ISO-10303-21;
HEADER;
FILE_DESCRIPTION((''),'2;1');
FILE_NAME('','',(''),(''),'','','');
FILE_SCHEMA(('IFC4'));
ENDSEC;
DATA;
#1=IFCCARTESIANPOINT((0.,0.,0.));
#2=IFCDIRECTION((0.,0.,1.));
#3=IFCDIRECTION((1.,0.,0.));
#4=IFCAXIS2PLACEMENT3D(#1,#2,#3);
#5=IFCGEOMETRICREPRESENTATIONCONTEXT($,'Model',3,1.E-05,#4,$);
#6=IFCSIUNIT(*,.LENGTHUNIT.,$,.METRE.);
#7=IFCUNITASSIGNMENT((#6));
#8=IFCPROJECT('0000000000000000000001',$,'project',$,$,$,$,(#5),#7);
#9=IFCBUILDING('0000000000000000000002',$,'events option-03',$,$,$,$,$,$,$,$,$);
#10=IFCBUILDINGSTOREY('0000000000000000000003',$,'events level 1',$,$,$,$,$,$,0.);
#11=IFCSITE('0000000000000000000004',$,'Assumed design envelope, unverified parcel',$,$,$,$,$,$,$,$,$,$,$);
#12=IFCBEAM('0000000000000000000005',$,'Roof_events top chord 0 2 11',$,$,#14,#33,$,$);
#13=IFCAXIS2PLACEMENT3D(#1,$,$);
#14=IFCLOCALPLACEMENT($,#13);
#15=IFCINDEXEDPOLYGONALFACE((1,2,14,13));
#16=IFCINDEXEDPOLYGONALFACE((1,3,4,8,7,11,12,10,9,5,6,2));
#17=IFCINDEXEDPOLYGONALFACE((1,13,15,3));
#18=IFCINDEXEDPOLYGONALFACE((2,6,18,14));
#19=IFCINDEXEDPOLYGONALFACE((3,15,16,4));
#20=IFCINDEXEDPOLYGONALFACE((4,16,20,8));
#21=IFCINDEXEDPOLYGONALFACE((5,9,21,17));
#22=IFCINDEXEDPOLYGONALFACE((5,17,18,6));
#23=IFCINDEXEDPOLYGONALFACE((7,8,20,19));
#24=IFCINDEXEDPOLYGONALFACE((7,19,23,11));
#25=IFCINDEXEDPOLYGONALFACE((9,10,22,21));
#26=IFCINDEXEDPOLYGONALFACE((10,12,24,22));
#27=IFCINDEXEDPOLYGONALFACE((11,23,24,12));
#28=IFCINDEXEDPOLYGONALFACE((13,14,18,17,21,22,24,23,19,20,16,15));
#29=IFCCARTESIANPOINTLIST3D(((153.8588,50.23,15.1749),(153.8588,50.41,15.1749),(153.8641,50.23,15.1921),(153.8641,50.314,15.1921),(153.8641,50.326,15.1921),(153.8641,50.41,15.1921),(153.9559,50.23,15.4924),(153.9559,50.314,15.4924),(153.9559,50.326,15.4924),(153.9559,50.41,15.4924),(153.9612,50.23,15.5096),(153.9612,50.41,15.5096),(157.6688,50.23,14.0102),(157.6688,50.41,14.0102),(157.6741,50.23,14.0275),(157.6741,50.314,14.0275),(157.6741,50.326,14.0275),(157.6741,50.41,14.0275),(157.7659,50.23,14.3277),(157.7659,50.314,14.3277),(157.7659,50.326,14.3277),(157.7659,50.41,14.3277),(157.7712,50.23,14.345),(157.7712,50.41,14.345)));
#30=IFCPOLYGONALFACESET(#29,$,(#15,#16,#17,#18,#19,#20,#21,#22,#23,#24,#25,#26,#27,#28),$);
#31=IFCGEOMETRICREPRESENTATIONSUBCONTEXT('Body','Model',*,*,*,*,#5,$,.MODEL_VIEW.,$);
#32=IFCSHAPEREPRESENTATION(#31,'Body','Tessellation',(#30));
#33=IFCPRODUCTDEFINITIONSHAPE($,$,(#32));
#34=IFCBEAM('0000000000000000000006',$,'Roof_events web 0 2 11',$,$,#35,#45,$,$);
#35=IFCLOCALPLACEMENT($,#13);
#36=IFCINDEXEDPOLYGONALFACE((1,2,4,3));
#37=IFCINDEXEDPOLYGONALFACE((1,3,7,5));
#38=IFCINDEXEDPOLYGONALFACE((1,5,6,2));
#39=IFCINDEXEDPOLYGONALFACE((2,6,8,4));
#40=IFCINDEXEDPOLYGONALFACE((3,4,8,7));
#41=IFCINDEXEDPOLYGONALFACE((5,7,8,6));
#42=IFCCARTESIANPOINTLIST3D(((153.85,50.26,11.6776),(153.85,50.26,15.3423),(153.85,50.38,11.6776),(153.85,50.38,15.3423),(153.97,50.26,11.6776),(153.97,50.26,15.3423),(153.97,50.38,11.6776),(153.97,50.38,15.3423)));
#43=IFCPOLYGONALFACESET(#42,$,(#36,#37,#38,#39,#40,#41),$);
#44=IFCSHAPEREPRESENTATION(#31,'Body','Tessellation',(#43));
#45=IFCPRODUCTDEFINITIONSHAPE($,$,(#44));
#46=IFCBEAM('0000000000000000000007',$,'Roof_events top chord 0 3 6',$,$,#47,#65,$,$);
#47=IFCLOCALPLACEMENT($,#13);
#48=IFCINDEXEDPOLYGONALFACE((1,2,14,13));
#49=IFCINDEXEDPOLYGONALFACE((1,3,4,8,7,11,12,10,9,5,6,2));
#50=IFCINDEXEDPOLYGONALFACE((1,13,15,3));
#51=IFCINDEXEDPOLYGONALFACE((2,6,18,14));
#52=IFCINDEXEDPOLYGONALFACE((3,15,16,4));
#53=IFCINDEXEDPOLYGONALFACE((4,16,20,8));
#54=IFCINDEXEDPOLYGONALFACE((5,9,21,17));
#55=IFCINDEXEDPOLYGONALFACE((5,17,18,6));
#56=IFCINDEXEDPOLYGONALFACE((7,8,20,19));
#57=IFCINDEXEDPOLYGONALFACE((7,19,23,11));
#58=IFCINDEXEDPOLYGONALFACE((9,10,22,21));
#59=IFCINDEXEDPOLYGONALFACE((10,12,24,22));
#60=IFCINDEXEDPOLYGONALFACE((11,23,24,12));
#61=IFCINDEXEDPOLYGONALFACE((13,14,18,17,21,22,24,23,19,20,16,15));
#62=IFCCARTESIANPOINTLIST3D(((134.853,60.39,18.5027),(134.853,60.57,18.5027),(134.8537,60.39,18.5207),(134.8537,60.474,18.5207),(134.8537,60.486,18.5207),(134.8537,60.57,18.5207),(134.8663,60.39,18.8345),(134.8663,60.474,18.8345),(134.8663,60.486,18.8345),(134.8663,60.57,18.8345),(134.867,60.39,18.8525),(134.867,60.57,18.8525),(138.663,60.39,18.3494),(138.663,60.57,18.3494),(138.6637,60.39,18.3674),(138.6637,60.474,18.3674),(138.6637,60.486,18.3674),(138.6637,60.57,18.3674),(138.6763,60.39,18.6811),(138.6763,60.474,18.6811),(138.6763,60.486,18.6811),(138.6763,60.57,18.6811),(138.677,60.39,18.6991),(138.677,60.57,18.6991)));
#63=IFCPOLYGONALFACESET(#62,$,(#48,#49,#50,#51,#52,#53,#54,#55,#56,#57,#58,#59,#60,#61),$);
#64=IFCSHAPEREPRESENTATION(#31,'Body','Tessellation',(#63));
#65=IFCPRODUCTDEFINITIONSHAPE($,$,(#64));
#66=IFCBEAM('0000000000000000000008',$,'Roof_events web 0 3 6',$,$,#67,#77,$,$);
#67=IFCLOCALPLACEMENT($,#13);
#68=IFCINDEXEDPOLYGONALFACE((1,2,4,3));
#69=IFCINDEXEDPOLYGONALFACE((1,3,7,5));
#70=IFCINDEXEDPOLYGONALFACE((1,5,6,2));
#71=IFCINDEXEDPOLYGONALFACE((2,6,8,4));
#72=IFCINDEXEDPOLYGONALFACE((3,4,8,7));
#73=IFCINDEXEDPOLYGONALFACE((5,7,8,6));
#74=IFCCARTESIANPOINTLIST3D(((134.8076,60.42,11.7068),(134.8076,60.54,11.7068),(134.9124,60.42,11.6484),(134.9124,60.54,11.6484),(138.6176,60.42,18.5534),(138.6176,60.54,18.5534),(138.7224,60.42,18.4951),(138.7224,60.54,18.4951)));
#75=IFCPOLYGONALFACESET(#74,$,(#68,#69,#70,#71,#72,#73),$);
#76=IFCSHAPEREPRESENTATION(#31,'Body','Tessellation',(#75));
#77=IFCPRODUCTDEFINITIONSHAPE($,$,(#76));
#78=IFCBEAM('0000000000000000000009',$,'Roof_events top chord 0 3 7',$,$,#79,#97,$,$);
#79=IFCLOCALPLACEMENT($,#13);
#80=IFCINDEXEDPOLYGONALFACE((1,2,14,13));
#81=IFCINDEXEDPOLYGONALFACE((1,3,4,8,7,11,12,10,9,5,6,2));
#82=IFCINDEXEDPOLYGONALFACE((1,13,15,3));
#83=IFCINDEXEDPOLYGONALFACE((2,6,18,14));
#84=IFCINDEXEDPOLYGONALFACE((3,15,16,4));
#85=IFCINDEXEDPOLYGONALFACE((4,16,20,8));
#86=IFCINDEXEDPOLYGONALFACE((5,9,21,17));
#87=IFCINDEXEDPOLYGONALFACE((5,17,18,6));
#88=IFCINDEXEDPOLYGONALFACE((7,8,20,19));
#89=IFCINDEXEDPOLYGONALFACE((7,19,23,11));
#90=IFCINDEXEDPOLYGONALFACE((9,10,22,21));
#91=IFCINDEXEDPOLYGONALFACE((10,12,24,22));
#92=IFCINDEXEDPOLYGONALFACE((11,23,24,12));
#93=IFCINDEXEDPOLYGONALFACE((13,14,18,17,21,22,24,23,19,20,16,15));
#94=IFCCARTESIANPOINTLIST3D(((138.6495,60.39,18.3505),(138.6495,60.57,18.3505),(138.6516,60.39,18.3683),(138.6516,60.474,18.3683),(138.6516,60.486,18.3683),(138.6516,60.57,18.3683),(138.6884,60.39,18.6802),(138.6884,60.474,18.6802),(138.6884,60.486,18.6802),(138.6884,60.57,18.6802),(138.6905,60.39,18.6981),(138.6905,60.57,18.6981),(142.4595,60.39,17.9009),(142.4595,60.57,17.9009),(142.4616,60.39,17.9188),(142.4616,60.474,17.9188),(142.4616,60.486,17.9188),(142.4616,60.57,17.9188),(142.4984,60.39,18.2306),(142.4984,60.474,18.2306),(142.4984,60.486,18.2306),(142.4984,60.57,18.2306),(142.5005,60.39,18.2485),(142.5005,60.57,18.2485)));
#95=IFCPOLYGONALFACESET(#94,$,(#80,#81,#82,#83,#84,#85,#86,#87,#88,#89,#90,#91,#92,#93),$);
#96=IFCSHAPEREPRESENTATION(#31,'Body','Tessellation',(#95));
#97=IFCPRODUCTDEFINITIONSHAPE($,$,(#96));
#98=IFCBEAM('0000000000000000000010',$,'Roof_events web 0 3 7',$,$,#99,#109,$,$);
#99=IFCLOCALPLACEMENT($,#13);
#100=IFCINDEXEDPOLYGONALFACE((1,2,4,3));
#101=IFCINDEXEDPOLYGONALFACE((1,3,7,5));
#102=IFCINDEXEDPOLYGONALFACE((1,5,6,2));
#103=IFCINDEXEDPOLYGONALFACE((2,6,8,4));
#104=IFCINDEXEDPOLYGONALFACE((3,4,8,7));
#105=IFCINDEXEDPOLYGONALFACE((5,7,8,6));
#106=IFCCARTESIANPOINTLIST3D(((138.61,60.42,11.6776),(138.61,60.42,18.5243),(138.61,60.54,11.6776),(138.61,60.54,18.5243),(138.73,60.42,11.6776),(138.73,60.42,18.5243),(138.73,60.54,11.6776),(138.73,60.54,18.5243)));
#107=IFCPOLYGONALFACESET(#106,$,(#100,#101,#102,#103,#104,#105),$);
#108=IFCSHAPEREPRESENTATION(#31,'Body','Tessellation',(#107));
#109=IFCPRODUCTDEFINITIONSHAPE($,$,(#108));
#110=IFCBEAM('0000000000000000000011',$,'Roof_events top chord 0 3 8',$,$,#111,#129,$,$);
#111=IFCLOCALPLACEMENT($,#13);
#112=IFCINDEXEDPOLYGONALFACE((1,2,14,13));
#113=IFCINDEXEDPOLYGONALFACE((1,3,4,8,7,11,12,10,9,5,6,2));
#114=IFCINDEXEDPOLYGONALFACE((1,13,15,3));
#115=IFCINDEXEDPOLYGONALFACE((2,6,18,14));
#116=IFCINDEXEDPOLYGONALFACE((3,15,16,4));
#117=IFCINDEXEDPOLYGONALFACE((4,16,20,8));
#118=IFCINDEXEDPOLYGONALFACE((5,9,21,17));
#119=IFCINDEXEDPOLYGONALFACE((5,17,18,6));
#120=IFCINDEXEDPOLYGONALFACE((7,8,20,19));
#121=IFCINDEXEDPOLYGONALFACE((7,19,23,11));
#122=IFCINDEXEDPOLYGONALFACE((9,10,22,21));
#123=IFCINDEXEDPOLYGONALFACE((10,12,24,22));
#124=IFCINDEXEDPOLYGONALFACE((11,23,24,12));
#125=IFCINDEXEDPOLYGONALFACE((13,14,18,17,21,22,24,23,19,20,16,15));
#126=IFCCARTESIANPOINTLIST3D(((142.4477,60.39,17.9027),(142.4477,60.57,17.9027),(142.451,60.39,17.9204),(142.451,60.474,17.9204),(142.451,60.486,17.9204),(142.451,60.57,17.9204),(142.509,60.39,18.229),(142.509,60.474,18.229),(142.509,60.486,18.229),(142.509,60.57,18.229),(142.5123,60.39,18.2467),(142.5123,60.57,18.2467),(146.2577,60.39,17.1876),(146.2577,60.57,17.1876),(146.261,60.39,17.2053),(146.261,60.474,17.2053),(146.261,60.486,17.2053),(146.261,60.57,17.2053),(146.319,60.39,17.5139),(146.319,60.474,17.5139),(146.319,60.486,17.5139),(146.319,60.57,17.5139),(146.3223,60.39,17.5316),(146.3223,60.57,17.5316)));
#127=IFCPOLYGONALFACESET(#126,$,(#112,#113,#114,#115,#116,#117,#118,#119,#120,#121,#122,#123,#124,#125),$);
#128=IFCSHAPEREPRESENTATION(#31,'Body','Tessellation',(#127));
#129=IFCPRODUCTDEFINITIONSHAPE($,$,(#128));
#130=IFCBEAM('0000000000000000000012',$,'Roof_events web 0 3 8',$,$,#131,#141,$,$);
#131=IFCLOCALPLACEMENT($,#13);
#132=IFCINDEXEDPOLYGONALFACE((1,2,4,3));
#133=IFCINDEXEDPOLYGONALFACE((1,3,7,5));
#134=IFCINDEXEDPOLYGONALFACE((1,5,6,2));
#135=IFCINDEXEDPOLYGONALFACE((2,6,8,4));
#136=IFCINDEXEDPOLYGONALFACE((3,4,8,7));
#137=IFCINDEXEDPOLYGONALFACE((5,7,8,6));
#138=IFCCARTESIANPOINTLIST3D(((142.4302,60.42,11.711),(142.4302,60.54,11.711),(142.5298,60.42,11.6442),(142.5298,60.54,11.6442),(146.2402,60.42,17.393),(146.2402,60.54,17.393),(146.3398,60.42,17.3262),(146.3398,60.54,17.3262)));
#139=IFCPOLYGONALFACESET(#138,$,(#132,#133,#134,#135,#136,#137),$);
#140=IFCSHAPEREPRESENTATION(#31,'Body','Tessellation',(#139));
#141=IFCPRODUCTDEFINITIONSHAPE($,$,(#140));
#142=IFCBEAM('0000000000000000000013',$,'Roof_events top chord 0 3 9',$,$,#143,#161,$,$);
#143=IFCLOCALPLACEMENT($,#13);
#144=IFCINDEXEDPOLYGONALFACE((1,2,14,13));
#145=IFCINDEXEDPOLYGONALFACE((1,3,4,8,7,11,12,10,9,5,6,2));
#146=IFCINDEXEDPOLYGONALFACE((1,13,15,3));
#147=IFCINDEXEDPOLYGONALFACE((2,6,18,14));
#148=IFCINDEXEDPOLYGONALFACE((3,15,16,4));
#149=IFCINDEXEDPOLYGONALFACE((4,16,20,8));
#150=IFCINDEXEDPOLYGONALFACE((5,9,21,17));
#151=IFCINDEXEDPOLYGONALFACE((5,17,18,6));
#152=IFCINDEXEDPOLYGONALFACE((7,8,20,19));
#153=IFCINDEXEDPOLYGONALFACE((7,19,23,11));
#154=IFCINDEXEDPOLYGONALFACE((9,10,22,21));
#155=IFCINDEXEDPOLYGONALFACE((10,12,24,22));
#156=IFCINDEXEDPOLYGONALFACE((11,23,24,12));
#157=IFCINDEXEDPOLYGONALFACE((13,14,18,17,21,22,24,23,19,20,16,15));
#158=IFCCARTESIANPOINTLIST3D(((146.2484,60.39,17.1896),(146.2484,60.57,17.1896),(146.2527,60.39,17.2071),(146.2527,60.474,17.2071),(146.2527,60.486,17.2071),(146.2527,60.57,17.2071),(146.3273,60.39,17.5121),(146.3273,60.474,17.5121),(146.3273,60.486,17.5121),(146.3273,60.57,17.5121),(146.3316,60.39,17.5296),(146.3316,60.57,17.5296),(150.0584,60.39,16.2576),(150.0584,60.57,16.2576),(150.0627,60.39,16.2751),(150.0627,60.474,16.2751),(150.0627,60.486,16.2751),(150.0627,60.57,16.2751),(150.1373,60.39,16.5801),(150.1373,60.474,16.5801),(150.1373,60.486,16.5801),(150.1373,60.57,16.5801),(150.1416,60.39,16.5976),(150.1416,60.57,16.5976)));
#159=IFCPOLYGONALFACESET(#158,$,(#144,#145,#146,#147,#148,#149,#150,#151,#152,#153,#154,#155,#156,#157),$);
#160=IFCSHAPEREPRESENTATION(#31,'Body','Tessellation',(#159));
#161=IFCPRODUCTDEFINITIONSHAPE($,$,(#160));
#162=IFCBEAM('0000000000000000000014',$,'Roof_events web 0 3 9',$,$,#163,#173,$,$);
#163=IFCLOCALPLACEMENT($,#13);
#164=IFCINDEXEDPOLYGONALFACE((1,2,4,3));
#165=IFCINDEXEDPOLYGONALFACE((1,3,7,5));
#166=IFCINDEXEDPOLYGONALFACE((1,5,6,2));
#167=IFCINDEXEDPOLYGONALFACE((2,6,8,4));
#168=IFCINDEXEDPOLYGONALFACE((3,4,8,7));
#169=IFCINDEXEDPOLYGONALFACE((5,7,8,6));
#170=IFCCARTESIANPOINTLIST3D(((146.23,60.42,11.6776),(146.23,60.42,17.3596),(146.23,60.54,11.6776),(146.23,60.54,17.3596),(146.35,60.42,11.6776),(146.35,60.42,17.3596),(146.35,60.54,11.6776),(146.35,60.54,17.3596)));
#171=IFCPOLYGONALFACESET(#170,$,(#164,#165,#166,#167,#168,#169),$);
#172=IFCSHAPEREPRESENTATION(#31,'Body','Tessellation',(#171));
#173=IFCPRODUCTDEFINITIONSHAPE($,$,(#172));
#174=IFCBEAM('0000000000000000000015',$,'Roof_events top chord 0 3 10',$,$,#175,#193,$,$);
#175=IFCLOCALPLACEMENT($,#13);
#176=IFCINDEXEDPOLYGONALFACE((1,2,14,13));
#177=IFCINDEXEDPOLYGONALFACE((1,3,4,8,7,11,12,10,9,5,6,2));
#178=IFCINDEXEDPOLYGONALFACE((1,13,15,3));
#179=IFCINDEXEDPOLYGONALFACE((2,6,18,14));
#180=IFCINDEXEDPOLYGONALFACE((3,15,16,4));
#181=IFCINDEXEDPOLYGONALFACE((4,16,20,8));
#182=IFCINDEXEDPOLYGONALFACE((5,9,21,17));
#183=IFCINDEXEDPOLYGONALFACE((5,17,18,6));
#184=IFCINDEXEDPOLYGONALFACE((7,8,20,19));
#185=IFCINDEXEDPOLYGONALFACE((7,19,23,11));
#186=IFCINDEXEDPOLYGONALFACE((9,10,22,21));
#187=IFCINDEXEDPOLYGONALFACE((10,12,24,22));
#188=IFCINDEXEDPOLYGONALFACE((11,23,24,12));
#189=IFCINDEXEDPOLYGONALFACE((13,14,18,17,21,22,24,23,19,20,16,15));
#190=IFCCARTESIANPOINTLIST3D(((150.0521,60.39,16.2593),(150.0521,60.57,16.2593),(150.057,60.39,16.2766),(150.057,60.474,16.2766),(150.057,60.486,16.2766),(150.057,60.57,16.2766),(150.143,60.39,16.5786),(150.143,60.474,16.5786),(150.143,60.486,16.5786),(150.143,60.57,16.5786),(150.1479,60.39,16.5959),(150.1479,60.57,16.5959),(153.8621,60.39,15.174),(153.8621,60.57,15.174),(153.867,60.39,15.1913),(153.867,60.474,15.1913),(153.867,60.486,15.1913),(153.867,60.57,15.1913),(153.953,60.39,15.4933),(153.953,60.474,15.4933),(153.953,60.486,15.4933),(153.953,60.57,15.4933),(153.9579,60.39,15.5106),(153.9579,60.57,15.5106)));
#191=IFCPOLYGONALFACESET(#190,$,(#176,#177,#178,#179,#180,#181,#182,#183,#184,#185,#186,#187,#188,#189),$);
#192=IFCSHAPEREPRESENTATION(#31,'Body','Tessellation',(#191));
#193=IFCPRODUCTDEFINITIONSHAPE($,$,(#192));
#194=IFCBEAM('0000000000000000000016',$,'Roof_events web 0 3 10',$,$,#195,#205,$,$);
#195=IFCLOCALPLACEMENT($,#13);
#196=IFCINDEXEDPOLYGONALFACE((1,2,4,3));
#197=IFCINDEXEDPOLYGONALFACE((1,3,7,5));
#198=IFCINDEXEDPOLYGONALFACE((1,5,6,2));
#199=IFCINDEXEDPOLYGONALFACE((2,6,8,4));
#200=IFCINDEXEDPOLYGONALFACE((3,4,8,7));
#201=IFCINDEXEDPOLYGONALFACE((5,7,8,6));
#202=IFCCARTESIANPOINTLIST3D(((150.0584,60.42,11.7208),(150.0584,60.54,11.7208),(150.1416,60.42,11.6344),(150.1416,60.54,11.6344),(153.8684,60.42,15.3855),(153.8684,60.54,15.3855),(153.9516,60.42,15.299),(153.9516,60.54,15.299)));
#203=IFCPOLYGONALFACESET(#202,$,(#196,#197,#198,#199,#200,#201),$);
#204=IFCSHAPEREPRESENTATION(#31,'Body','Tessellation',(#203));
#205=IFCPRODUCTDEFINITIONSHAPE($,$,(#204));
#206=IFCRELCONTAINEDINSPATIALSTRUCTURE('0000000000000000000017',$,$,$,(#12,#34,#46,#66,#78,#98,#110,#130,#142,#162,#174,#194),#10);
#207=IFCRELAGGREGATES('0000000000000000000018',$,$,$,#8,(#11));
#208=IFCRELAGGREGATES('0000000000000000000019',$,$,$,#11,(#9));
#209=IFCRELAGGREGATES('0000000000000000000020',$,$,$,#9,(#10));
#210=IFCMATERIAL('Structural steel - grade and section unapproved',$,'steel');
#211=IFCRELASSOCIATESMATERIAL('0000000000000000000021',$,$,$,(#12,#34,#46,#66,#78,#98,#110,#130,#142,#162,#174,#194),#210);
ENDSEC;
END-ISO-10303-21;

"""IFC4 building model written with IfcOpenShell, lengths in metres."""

from ifc_helpers import new_model, si_unit, frame, origin_with_axes, place, context, subcontext, project, spatial, rectangle, i_section, extrude, material, element, save


model = new_model("IFC4")

# Units and contexts
model_context = context("Model", 3, precision=1e-05, world=origin_with_axes())
body_context = subcontext(model_context, "Body", "Model", "MODEL_VIEW")
ifc_project = project(units=[si_unit("LENGTHUNIT", "METRE")], contexts=[model_context])

# Site, building, storey
site = spatial("IfcSite", under=ifc_project, Name="Assumed design envelope, unverified parcel")
building = spatial("IfcBuilding", under=site, Name="events option-03")
storey = spatial("IfcBuildingStorey", under=building, Name="events level 1", Elevation=0.0)

# Beams
ifc_material = material(Name="Structural steel - grade and section unapproved", Category="steel")
beam_1_placement = place(None, frame((153.91, 50.32, 15.3423), z_axis=(0.956315, 0.0, -0.292338), x_axis=(0.0, 1.0, 0.0)))
element("IfcBeam", 1, at=beam_1_placement, inside=storey, material=ifc_material, Name="Roof_events top chord 0 2 11", context=body_context, shape_type="SweptSolid", body=[
    extrude(i_section(OverallWidth=0.18, OverallDepth=0.35, WebThickness=0.012, FlangeThickness=0.018, FilletRadius=0.0), origin_with_axes(), (0.0, 0.0, 1.0), 3.984),
])
beam_2_placement = place(None, frame((153.91, 50.32, 11.6776), z_axis=(0.0, 0.0, 1.0), x_axis=(-1.0, 0.0, 0.0)))
element("IfcBeam", 2, at=beam_2_placement, inside=storey, material=ifc_material, Name="Roof_events web 0 2 11", context=body_context, shape_type="SweptSolid", body=[
    extrude(rectangle(XDim=0.12, YDim=0.12), origin_with_axes(), (0.0, 0.0, 1.0), 3.6647),
])
beam_3_placement = place(None, frame((134.86, 60.48, 18.6776), z_axis=(0.999191, 0.0, -0.040212), x_axis=(0.0, 1.0, 0.0)))
element("IfcBeam", 3, at=beam_3_placement, inside=storey, material=ifc_material, Name="Roof_events top chord 0 3 6", context=body_context, shape_type="SweptSolid", body=[
    extrude(i_section(OverallWidth=0.18, OverallDepth=0.35, WebThickness=0.012, FlangeThickness=0.018, FilletRadius=0.0), origin_with_axes(), (0.0, 0.0, 1.0), 3.8131),
])
beam_4_placement = place(None, frame((134.86, 60.48, 11.6776), z_axis=(0.486257, 0.0, 0.873816), x_axis=(0.0, 1.0, 0.0)))
element("IfcBeam", 4, at=beam_4_placement, inside=storey, material=ifc_material, Name="Roof_events web 0 3 6", context=body_context, shape_type="SweptSolid", body=[
    extrude(rectangle(XDim=0.12, YDim=0.12), origin_with_axes(), (0.0, 0.0, 1.0), 7.8354),
])
beam_5_placement = place(None, frame((138.67, 60.48, 18.5243), z_axis=(0.993111, 0.0, -0.11718), x_axis=(0.0, 1.0, 0.0)))
element("IfcBeam", 5, at=beam_5_placement, inside=storey, material=ifc_material, Name="Roof_events top chord 0 3 7", context=body_context, shape_type="SweptSolid", body=[
    extrude(i_section(OverallWidth=0.18, OverallDepth=0.35, WebThickness=0.012, FlangeThickness=0.018, FilletRadius=0.0), origin_with_axes(), (0.0, 0.0, 1.0), 3.8364),
])
beam_6_placement = place(None, frame((138.67, 60.48, 11.6776), z_axis=(0.0, 0.0, 1.0), x_axis=(-1.0, 0.0, 0.0)))
element("IfcBeam", 6, at=beam_6_placement, inside=storey, material=ifc_material, Name="Roof_events web 0 3 7", context=body_context, shape_type="SweptSolid", body=[
    extrude(rectangle(XDim=0.12, YDim=0.12), origin_with_axes(), (0.0, 0.0, 1.0), 6.8467),
])
beam_7_placement = place(None, frame((142.48, 60.48, 18.0747), z_axis=(0.982837, 0.0, -0.184478), x_axis=(0.0, 1.0, 0.0)))
element("IfcBeam", 7, at=beam_7_placement, inside=storey, material=ifc_material, Name="Roof_events top chord 0 3 8", context=body_context, shape_type="SweptSolid", body=[
    extrude(i_section(OverallWidth=0.18, OverallDepth=0.35, WebThickness=0.012, FlangeThickness=0.018, FilletRadius=0.0), origin_with_axes(), (0.0, 0.0, 1.0), 3.8765),
])
beam_8_placement = place(None, frame((142.48, 60.48, 11.6776), z_axis=(0.556926, 0.0, 0.830562), x_axis=(0.0, 1.0, 0.0)))
element("IfcBeam", 8, at=beam_8_placement, inside=storey, material=ifc_material, Name="Roof_events web 0 3 8", context=body_context, shape_type="SweptSolid", body=[
    extrude(rectangle(XDim=0.12, YDim=0.12), origin_with_axes(), (0.0, 0.0, 1.0), 6.8411),
])
beam_9_placement = place(None, frame((146.29, 60.48, 17.3596), z_axis=(0.971361, 0.0, -0.237608), x_axis=(0.0, 1.0, 0.0)))
element("IfcBeam", 9, at=beam_9_placement, inside=storey, material=ifc_material, Name="Roof_events top chord 0 3 9", context=body_context, shape_type="SweptSolid", body=[
    extrude(i_section(OverallWidth=0.18, OverallDepth=0.35, WebThickness=0.012, FlangeThickness=0.018, FilletRadius=0.0), origin_with_axes(), (0.0, 0.0, 1.0), 3.9223),
])
beam_10_placement = place(None, frame((146.29, 60.48, 11.6776), z_axis=(0.0, 0.0, 1.0), x_axis=(-1.0, 0.0, 0.0)))
element("IfcBeam", 10, at=beam_10_placement, inside=storey, material=ifc_material, Name="Roof_events web 0 3 9", context=body_context, shape_type="SweptSolid", body=[
    extrude(rectangle(XDim=0.12, YDim=0.12), origin_with_axes(), (0.0, 0.0, 1.0), 5.682),
])
beam_11_placement = place(None, frame((150.1, 60.48, 16.4276), z_axis=(0.961741, 0.0, -0.273961), x_axis=(0.0, 1.0, 0.0)))
element("IfcBeam", 11, at=beam_11_placement, inside=storey, material=ifc_material, Name="Roof_events top chord 0 3 10", context=body_context, shape_type="SweptSolid", body=[
    extrude(i_section(OverallWidth=0.18, OverallDepth=0.35, WebThickness=0.012, FlangeThickness=0.018, FilletRadius=0.0), origin_with_axes(), (0.0, 0.0, 1.0), 3.9616),
])
beam_12_placement = place(None, frame((150.1, 60.48, 11.6776), z_axis=(0.720717, 0.0, 0.693229), x_axis=(0.0, 1.0, 0.0)))
element("IfcBeam", 12, at=beam_12_placement, inside=storey, material=ifc_material, Name="Roof_events web 0 3 10", context=body_context, shape_type="SweptSolid", body=[
    extrude(rectangle(XDim=0.12, YDim=0.12), origin_with_axes(), (0.0, 0.0, 1.0), 5.2864),
])

save(model, "model.ifc")
